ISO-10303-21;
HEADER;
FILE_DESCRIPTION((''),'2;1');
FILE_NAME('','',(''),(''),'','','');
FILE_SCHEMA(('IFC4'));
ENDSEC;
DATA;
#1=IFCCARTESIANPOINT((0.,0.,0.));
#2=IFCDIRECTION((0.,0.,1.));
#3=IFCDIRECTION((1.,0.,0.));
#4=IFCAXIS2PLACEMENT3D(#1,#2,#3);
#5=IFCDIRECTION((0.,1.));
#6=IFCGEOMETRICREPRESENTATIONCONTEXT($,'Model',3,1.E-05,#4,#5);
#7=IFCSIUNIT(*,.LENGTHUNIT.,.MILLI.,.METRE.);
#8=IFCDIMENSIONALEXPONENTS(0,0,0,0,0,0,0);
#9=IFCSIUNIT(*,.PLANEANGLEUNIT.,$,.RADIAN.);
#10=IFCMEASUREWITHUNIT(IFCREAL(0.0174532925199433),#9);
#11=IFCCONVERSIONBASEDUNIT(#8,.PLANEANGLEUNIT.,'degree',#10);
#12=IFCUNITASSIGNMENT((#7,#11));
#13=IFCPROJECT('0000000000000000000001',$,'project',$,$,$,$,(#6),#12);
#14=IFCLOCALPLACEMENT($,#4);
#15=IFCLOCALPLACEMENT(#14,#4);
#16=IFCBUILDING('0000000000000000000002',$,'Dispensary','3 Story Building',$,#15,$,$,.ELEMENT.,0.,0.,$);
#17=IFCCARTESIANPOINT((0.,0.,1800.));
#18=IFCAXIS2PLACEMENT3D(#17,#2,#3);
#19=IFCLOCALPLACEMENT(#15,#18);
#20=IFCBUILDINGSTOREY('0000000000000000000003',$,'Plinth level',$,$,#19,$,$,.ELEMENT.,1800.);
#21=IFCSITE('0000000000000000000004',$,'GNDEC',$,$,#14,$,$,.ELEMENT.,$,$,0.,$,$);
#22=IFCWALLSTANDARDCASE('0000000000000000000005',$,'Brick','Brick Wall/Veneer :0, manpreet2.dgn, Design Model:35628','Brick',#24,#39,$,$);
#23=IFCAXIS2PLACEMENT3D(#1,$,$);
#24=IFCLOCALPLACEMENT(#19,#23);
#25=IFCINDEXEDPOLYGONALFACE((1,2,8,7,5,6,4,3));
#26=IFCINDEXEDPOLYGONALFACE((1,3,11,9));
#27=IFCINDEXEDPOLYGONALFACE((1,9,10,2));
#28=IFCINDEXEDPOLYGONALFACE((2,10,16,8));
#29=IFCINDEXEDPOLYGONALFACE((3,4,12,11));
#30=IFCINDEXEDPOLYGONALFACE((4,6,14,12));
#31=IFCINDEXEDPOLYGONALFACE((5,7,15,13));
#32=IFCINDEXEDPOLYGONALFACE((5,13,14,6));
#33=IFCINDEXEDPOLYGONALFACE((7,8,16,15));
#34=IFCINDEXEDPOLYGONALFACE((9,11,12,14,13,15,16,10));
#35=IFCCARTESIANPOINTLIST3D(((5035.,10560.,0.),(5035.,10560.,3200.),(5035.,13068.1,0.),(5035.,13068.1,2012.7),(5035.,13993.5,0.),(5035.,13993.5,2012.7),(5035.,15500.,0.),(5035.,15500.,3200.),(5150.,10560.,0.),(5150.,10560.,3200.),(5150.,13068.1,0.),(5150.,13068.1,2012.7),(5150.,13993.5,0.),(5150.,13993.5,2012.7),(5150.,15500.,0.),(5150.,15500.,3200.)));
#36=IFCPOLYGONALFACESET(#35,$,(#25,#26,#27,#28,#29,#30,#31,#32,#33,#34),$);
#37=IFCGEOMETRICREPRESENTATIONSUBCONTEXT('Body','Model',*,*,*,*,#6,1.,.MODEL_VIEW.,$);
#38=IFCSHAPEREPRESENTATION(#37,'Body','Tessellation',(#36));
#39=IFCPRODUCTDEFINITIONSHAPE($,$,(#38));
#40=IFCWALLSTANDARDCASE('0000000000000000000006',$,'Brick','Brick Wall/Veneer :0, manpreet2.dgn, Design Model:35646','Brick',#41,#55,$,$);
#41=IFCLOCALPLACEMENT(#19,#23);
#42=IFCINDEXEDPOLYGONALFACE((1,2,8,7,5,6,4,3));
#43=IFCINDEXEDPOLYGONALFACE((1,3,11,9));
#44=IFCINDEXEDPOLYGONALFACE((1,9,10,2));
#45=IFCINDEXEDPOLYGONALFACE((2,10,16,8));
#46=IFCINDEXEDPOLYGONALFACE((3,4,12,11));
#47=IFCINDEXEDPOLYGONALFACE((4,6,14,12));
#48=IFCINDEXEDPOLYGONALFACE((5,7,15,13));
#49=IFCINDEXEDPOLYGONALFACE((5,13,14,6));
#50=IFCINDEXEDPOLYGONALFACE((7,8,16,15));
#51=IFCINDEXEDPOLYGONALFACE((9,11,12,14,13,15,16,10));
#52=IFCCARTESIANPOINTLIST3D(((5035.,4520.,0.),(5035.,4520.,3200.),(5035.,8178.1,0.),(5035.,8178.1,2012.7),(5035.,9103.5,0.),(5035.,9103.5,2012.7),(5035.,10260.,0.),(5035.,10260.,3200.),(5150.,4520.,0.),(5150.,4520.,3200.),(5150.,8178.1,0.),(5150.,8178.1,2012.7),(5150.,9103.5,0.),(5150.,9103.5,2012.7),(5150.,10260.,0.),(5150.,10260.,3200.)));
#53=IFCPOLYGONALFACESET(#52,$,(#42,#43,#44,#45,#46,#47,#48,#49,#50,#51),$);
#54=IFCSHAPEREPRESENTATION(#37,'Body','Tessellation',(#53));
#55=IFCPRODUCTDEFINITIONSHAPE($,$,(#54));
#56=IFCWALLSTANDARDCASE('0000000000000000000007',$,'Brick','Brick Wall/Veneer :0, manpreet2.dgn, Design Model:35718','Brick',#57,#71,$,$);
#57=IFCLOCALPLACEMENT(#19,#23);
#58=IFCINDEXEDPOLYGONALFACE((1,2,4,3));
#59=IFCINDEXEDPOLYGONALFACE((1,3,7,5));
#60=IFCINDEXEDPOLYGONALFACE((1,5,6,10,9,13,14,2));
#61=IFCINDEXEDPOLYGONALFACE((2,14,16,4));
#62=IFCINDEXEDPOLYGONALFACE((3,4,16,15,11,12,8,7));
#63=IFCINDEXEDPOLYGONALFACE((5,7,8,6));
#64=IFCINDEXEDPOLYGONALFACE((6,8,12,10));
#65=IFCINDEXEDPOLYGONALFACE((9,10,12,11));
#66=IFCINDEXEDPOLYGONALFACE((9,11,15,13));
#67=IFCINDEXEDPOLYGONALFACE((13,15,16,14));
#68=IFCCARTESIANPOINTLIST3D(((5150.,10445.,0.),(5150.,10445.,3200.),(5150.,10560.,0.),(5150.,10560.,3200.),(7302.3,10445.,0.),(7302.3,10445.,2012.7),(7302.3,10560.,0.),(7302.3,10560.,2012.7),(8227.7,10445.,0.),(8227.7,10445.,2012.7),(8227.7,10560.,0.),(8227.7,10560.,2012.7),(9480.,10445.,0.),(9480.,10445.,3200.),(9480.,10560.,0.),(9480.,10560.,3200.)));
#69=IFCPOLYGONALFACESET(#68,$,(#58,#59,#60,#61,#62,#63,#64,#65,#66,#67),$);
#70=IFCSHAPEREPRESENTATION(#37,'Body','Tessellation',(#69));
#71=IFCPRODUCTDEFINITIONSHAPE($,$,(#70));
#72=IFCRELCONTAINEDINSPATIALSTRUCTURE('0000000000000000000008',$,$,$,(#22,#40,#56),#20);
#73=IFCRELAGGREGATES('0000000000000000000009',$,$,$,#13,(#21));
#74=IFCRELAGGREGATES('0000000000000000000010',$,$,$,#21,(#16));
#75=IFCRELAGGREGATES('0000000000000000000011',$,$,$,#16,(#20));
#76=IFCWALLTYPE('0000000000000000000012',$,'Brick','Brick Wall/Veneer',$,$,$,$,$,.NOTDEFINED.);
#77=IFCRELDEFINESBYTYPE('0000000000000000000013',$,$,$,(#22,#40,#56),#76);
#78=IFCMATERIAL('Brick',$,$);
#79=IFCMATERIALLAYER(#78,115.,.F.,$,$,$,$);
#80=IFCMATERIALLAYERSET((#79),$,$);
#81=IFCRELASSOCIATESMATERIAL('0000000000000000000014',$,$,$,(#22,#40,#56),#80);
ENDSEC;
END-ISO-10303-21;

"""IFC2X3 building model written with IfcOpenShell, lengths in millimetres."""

from ifc_helpers import new_model, entity, si_unit, converted_unit, direction, frame, frame_2d, origin_with_axes, place, context, subcontext, project, spatial, rectangle, extrude, material, layer, layer_set, layer_usage, type_object, element, save


model = new_model("IFC2X3")

# Units and contexts
model_context = context("Model", 3, precision=1e-05, world=origin_with_axes(), true_north=direction((0.0, 1.0)))
body_context = subcontext(model_context, "Body", "Model", "MODEL_VIEW", scale=1.0)
ifc_project = project(units=[si_unit("LENGTHUNIT", "METRE", prefix="MILLI"), converted_unit("PLANEANGLEUNIT", "degree", entity("IfcReal", 0.0174532925199433), si_unit("PLANEANGLEUNIT", "RADIAN"), dimensions=[0, 0, 0, 0, 0, 0, 0])], contexts=[model_context])

# Site, building, storey
site_placement = place(None, origin_with_axes())
site = spatial("IfcSite", under=ifc_project, at=site_placement, Name="GNDEC", CompositionType="ELEMENT", RefElevation=0.0)
building_placement = place(site_placement, origin_with_axes())
building = spatial("IfcBuilding", under=site, at=building_placement, Name="Dispensary", Description="3 Story Building", CompositionType="ELEMENT", ElevationOfRefHeight=0.0, ElevationOfTerrain=0.0)
storey_placement = place(building_placement, frame((0.0, 0.0, 1800.0), z_axis=(0.0, 0.0, 1.0), x_axis=(1.0, 0.0, 0.0)))
storey = spatial("IfcBuildingStorey", under=building, at=storey_placement, Name="Plinth level", CompositionType="ELEMENT", Elevation=1800.0)

# Shared definitions
ifc_material_1 = material(Name="Brick")
wall_type = type_object("IfcWallType", Name="Brick", Description="Brick Wall/Veneer", PredefinedType="NOTDEFINED")

# Walls, openings
ifc_layer_1 = layer(ifc_material_1, 115.0, ventilated=False)
ifc_layer_set_1 = layer_set([ifc_layer_1])
ifc_layer_usage_1 = layer_usage(ifc_layer_set_1, "AXIS2", "POSITIVE", 0.0)
wall_1_placement = place(storey_placement, frame((5150.0, 15500.0, 0.0), z_axis=(0.0, 0.0, 1.0), x_axis=(0.0, -1.0, 0.0)))
wall_1 = element("IfcWallStandardCase", 1, at=wall_1_placement, inside=storey, type_object=wall_type, material=ifc_layer_usage_1, Name="Brick", Description="Brick Wall/Veneer :0, manpreet2.dgn, Design Model:35628", ObjectType="Brick", context=body_context, shape_type="SweptSolid", body=[
    extrude(rectangle(XDim=4940.0, YDim=115.0, at=frame_2d((2470.0, -57.5), x_axis=(-1.0, 0.0))), origin_with_axes(), (0.0, 0.0, 1.0), 3200.0),
])
opening_1_placement = place(wall_1_placement, frame((1506.5, -115.0, 0.0), z_axis=(0.0, 0.0, 1.0), x_axis=(1.0, 0.0, 0.0)))
element("IfcOpeningElement", 2, at=opening_1_placement, cuts=wall_1, ObjectType="Opening", context=body_context, shape_type="SweptSolid", body=[
    extrude(rectangle(XDim=2012.7, YDim=925.4, at=frame_2d((-462.7, 1006.4), x_axis=(0.0, -1.0))), frame((0.0, 0.0, 0.0), z_axis=(0.0, 1.0, 0.0), x_axis=(-1.0, 0.0, 0.0)), (0.0, 0.0, 1.0), 115.0),
])
wall_2_placement = place(storey_placement, frame((5150.0, 10260.0, 0.0), z_axis=(0.0, 0.0, 1.0), x_axis=(0.0, -1.0, 0.0)))
wall_2 = element("IfcWallStandardCase", 3, at=wall_2_placement, inside=storey, type_object=wall_type, material=ifc_layer_usage_1, Name="Brick", Description="Brick Wall/Veneer :0, manpreet2.dgn, Design Model:35646", ObjectType="Brick", context=body_context, shape_type="SweptSolid", body=[
    extrude(rectangle(XDim=5740.0, YDim=115.0, at=frame_2d((2870.0, -57.5), x_axis=(-1.0, 0.0))), origin_with_axes(), (0.0, 0.0, 1.0), 3200.0),
])
opening_2_placement = place(wall_2_placement, frame((1156.5, -115.0, 0.0), z_axis=(0.0, 0.0, 1.0), x_axis=(1.0, 0.0, 0.0)))
element("IfcOpeningElement", 4, at=opening_2_placement, cuts=wall_2, ObjectType="Opening", context=body_context, shape_type="SweptSolid", body=[
    extrude(rectangle(XDim=2012.7, YDim=925.4, at=frame_2d((-462.7, 1006.4), x_axis=(0.0, -1.0))), frame((0.0, 0.0, 0.0), z_axis=(0.0, 1.0, 0.0), x_axis=(-1.0, 0.0, 0.0)), (0.0, 0.0, 1.0), 115.0),
])
wall_3_placement = place(storey_placement, frame((5150.0, 10560.0, 0.0), z_axis=(0.0, 0.0, 1.0), x_axis=(1.0, 0.0, 0.0)))
wall_3 = element("IfcWallStandardCase", 5, at=wall_3_placement, inside=storey, type_object=wall_type, material=ifc_layer_usage_1, Name="Brick", Description="Brick Wall/Veneer :0, manpreet2.dgn, Design Model:35718", ObjectType="Brick", context=body_context, shape_type="SweptSolid", body=[
    extrude(rectangle(XDim=4330.0, YDim=115.0, at=frame_2d((2165.0, -57.5), x_axis=(-1.0, 0.0))), origin_with_axes(), (0.0, 0.0, 1.0), 3200.0),
])
opening_3_placement = place(wall_3_placement, frame((2152.3, -115.0, 0.0), z_axis=(0.0, 0.0, 1.0), x_axis=(1.0, 0.0, 0.0)))
element("IfcOpeningElement", 6, at=opening_3_placement, cuts=wall_3, ObjectType="Opening", context=body_context, shape_type="SweptSolid", body=[
    extrude(rectangle(XDim=2012.7, YDim=925.4, at=frame_2d((-462.7, 1006.4), x_axis=(0.0, -1.0))), frame((0.0, 0.0, 0.0), z_axis=(0.0, 1.0, 0.0), x_axis=(-1.0, 0.0, 0.0)), (0.0, 0.0, 1.0), 115.0),
])

save(model, "model.ifc")
